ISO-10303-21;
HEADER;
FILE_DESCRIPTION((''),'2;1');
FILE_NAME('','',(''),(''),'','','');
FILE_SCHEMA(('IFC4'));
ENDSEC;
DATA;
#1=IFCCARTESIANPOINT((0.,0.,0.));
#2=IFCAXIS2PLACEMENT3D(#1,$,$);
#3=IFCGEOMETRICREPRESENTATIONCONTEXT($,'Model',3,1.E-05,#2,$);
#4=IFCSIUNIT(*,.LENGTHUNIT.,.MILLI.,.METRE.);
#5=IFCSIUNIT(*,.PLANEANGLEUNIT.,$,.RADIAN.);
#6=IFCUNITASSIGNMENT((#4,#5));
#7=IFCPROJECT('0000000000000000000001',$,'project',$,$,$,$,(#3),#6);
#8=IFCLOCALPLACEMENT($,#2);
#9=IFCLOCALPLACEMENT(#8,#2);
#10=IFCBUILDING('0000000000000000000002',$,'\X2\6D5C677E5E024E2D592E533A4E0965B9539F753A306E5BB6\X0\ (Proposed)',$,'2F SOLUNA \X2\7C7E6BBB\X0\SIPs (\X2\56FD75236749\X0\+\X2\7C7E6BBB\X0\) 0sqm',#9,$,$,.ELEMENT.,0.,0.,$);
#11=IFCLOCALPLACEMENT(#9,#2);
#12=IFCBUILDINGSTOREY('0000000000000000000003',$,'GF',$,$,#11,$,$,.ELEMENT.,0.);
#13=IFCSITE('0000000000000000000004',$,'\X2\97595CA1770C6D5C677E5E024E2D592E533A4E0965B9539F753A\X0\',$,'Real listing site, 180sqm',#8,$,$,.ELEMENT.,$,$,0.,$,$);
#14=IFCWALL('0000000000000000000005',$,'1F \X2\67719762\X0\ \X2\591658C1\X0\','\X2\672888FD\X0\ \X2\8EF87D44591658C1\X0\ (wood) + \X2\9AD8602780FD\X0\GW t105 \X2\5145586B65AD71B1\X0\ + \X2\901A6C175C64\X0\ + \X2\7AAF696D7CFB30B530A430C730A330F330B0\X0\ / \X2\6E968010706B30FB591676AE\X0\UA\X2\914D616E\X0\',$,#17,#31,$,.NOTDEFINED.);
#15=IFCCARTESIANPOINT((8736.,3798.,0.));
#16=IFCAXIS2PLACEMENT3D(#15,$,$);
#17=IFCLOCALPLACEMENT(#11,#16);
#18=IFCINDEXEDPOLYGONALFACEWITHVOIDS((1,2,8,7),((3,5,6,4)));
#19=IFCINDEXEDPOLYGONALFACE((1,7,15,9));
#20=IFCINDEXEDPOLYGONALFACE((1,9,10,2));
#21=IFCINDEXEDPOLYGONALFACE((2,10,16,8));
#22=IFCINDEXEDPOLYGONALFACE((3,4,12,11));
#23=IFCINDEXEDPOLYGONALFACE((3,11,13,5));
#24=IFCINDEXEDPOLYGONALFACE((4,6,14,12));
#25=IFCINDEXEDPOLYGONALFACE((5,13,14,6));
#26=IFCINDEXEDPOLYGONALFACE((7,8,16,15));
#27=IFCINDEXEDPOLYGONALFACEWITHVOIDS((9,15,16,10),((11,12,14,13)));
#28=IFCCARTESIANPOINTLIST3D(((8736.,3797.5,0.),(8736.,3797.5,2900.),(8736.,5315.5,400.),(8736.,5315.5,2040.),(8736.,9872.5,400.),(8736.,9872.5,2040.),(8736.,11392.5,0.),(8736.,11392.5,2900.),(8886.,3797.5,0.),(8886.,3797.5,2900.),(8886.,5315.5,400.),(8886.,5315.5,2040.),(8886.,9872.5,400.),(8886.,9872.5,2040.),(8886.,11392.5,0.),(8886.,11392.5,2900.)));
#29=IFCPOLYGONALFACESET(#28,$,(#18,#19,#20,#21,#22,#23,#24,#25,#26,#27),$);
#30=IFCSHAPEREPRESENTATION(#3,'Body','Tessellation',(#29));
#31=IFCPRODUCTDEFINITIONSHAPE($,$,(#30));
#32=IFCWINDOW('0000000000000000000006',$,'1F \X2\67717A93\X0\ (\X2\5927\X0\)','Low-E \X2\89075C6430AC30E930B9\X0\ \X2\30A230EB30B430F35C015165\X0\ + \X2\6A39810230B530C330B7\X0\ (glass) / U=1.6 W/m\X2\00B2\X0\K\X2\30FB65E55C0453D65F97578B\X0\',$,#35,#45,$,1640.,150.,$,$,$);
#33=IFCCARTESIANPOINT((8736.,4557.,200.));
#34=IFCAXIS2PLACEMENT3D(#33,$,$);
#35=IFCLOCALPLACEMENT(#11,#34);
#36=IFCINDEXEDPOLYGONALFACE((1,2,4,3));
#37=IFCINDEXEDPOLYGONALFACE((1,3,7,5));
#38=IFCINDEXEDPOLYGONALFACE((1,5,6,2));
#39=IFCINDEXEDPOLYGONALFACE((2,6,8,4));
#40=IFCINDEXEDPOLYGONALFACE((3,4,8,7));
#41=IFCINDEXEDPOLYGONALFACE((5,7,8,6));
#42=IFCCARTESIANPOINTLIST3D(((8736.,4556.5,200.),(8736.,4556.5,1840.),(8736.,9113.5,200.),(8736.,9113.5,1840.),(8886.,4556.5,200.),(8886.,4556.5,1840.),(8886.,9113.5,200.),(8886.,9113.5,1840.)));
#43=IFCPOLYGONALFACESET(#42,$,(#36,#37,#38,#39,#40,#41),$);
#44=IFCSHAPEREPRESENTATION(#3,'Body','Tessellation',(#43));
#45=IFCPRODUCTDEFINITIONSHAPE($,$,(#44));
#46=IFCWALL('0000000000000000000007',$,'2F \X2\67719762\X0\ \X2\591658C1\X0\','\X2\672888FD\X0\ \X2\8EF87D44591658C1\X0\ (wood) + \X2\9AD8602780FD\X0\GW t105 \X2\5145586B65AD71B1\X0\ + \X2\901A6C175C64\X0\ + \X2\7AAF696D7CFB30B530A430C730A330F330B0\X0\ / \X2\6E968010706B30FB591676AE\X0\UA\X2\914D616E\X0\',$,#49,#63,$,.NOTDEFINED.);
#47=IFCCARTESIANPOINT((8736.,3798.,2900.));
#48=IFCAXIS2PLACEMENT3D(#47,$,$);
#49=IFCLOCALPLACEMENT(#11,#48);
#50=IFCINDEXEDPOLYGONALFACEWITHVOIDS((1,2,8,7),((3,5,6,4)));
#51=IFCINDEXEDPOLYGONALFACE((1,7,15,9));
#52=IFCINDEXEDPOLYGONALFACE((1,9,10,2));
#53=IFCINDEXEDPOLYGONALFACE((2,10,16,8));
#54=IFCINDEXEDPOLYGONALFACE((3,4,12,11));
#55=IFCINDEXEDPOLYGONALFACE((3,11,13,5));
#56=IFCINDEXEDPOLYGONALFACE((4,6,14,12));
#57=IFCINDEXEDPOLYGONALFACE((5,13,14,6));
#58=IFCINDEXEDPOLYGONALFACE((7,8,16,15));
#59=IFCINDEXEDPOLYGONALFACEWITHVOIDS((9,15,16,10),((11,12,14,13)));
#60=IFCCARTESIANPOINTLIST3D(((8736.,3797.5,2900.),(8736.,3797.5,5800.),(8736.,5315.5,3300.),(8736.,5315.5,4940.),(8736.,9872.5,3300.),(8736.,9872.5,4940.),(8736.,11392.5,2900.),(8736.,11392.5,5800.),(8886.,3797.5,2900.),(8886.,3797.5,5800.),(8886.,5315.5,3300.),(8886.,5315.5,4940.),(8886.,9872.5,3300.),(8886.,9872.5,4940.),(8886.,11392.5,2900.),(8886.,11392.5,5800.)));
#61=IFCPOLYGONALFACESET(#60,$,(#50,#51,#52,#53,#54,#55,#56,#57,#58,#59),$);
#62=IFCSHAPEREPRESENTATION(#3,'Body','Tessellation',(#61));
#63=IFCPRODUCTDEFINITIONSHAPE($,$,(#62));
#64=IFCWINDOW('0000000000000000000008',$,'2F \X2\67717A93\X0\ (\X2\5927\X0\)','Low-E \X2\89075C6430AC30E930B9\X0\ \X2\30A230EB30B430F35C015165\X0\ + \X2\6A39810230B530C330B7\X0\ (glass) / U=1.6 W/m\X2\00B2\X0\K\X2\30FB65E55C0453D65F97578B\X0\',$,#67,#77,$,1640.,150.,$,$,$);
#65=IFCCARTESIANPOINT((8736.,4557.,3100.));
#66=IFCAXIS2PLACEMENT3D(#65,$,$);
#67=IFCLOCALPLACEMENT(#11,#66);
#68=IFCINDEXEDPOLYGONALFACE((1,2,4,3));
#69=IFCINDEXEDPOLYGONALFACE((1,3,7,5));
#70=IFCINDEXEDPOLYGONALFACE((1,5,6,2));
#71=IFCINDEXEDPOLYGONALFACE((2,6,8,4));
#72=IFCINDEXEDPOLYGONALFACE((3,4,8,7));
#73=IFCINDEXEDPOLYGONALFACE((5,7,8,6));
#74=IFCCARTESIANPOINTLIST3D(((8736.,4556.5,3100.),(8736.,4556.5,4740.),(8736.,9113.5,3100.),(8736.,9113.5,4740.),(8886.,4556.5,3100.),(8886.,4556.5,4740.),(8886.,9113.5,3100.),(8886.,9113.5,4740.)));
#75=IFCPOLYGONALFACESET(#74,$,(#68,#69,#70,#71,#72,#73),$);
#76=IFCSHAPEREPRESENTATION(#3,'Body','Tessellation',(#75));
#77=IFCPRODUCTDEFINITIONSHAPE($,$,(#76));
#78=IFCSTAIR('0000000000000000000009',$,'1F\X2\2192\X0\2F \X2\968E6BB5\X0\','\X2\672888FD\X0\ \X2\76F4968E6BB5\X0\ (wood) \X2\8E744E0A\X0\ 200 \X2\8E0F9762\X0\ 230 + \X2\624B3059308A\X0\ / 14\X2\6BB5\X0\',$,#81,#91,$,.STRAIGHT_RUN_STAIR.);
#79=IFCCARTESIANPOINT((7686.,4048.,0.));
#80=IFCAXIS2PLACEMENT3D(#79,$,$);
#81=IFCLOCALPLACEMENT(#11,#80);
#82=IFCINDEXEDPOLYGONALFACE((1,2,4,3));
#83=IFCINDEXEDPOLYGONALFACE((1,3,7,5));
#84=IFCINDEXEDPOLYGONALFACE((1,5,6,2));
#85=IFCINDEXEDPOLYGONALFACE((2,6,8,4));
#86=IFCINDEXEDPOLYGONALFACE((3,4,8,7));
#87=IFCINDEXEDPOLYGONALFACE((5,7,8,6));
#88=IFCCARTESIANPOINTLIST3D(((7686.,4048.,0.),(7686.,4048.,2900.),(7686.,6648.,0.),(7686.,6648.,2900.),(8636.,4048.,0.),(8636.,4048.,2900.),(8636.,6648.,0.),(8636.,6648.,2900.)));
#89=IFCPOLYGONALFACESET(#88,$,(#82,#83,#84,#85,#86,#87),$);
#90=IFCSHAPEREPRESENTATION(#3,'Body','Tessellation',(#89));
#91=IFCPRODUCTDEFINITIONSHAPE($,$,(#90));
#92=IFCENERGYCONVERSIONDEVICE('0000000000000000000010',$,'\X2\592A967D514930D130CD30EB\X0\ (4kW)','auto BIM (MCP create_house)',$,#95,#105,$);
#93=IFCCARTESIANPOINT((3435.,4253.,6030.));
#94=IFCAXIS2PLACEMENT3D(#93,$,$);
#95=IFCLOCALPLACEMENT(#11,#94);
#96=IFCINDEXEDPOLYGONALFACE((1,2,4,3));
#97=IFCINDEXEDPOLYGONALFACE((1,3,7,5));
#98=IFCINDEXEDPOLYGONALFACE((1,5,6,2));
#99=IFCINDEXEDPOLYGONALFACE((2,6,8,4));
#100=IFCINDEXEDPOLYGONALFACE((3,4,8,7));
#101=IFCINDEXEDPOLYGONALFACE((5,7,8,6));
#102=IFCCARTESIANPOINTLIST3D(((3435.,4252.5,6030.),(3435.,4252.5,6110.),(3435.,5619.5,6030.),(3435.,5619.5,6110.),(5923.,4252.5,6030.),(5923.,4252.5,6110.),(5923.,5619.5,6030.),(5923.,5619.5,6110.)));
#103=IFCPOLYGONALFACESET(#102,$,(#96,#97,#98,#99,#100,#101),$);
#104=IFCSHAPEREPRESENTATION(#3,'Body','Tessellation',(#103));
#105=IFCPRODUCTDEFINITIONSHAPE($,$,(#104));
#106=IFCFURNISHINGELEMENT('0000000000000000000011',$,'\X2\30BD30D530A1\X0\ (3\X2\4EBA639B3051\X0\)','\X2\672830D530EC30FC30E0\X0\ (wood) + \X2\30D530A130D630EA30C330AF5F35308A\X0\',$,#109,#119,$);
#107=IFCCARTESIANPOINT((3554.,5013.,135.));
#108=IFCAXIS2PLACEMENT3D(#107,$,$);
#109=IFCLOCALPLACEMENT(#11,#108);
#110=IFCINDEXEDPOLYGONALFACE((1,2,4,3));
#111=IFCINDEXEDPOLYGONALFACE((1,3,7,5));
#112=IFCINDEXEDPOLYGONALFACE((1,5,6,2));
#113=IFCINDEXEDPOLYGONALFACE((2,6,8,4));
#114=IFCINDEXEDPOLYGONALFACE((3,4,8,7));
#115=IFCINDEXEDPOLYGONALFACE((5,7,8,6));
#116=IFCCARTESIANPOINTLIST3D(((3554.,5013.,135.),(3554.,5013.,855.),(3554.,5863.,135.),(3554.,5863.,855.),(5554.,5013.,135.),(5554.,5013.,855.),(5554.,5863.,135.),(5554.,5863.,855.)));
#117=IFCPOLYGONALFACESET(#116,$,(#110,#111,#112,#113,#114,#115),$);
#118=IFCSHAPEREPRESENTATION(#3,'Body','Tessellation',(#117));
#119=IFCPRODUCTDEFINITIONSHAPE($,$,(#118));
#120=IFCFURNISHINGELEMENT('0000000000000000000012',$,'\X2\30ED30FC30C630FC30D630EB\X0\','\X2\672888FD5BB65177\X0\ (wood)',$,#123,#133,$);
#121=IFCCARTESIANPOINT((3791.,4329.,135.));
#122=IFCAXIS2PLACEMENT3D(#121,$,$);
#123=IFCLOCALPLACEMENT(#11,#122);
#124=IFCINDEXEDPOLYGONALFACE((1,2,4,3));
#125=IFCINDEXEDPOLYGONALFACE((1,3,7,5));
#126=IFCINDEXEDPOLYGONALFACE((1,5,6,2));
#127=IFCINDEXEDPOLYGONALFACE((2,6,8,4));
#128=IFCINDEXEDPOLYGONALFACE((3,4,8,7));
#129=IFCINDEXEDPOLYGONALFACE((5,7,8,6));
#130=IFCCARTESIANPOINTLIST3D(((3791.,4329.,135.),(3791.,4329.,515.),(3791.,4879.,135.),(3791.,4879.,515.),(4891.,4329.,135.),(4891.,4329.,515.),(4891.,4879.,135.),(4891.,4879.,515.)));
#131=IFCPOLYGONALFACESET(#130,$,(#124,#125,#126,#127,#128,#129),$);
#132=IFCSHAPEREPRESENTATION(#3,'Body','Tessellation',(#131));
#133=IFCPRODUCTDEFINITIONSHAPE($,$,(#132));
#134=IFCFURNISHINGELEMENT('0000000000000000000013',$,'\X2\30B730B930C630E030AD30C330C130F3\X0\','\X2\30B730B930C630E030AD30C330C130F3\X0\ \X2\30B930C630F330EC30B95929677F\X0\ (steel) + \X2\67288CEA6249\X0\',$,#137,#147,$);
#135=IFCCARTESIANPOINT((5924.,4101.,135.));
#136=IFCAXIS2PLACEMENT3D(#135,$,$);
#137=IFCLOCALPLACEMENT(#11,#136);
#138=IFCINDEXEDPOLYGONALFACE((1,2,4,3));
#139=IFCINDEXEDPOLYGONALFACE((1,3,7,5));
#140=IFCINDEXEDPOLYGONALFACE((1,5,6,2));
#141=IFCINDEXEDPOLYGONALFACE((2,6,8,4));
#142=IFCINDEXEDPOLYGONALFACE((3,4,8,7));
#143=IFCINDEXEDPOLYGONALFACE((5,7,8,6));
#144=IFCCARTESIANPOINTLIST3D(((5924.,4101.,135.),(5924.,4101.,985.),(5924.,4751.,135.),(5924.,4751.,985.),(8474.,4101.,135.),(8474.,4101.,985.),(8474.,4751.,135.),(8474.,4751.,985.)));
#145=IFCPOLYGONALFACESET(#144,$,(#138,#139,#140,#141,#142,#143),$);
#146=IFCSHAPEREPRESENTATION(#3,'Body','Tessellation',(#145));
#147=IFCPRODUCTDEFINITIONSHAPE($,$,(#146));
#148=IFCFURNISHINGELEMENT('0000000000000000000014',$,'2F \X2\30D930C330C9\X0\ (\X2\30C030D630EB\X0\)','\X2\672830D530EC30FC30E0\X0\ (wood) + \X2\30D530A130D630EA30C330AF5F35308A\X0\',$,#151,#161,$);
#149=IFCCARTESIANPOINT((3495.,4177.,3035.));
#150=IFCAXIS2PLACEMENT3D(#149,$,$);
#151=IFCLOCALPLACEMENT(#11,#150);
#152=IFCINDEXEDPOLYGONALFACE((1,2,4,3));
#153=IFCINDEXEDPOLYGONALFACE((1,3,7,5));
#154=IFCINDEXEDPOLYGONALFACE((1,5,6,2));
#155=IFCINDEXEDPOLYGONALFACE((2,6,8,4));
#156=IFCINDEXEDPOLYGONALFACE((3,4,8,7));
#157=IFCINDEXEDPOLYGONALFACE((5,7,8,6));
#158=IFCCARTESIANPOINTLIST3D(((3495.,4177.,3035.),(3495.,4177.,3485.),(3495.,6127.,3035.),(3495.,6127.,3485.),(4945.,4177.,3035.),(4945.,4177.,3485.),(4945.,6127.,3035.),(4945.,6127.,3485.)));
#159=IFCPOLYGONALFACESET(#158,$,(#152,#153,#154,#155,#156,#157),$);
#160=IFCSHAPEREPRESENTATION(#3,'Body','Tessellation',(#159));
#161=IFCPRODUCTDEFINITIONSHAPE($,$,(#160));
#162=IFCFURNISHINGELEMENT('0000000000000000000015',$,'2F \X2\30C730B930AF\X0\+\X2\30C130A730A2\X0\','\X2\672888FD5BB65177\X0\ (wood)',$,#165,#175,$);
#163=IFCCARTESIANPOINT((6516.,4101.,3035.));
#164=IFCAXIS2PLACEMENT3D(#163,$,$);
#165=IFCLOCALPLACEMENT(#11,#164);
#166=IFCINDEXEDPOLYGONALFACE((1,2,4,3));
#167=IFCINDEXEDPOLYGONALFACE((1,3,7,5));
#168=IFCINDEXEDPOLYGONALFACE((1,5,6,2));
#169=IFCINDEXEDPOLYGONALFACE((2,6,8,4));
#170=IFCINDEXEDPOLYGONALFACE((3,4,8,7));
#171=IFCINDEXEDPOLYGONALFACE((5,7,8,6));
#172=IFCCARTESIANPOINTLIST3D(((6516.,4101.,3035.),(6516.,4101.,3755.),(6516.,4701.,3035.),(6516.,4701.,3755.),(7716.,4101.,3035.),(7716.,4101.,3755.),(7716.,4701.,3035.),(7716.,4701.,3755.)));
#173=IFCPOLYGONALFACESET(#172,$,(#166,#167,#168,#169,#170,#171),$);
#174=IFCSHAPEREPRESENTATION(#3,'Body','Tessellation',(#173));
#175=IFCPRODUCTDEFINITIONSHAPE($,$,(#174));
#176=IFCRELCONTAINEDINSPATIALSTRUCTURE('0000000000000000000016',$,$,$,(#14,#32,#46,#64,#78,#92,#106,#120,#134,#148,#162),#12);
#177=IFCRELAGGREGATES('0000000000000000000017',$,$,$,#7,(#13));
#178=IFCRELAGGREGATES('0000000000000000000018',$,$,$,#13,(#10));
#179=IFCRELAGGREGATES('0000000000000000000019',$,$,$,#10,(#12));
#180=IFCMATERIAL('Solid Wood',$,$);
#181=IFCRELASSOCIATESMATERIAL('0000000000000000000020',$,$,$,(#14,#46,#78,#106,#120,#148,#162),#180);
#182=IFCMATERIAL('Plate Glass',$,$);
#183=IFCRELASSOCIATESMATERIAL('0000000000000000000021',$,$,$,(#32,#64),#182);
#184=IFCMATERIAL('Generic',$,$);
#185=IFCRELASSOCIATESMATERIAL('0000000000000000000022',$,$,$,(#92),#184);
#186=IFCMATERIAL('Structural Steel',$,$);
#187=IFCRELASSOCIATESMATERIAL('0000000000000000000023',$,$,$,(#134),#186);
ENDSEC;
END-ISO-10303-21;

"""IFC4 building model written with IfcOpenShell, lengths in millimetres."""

from ifc_helpers import new_model, si_unit, frame, frame_2d, origin, place, context, project, spatial, rectangle, extrude, material, element, fill, save


model = new_model("IFC4")

# Units and contexts
model_context = context("Model", 3, precision=1e-05, world=origin())
ifc_project = project(units=[si_unit("LENGTHUNIT", "METRE", prefix="MILLI"), si_unit("PLANEANGLEUNIT", "RADIAN")], contexts=[model_context])

# Site, building, storey
site_placement = place(None, origin())
site = spatial("IfcSite", under=ifc_project, at=site_placement, Name="静岡県浜松市中央区三方原町", ObjectType="Real listing site, 180sqm", CompositionType="ELEMENT", RefElevation=0.0)
building_placement = place(site_placement, origin())
building = spatial("IfcBuilding", under=site, at=building_placement, Name="浜松市中央区三方原町の家 (Proposed)", ObjectType="2F SOLUNA 籾殻SIPs (国産杉+籾殻) 0sqm", CompositionType="ELEMENT", ElevationOfRefHeight=0.0, ElevationOfTerrain=0.0)
storey_placement = place(building_placement, origin())
storey = spatial("IfcBuildingStorey", under=building, at=storey_placement, Name="GF", CompositionType="ELEMENT", Elevation=0.0)

# Wall, opening, window
ifc_material_1 = material(Name="Solid Wood")
wall_1_placement = place(storey_placement, frame((8736.0, 3798.0, 0.0)))
wall_1 = element("IfcWall", 1, at=wall_1_placement, inside=storey, material=ifc_material_1, Name="1F 東面 外壁", Description="木製 軸組外壁 (wood) + 高性能GW t105 充填断熱 + 通気層 + 窯業系サイディング / 準耐火・外皮UA配慮", PredefinedType="NOTDEFINED", context=model_context, shape_type="SweptSolid", body=[
    extrude(rectangle(XDim=150.0, YDim=7595.0, at=frame_2d((75.0, 3797.0))), frame((8736.0, 3798.0, 0.0)), (0.0, 0.0, 1.0), 2900.0),
])
opening_1_placement = place(storey_placement, frame((8736.0, 4557.0, 200.0)))
opening_1 = element("IfcOpeningElement", 2, at=opening_1_placement, cuts=wall_1, PredefinedType="NOTDEFINED", context=model_context, shape_type="SweptSolid", body=[
    extrude(rectangle(XDim=150.0, YDim=4557.0, at=frame_2d((75.0, 2278.0))), frame((8736.0, 4557.0, 200.0)), (0.0, 0.0, 1.0), 1640.0),
])
ifc_material_2 = material(Name="Plate Glass")
window_1_placement = place(storey_placement, frame((8736.0, 4557.0, 200.0)))
window_1 = element("IfcWindow", 3, at=window_1_placement, inside=storey, material=ifc_material_2, Name="1F 東窓 (大)", Description="Low-E 複層ガラス アルゴン封入 + 樹脂サッシ (glass) / U=1.6 W/m²K・日射取得型", OverallHeight=1640.0, OverallWidth=150.0, context=model_context, shape_type="SweptSolid", body=[
    extrude(rectangle(XDim=150.0, YDim=4557.0, at=frame_2d((75.0, 2278.0))), frame((8736.0, 4557.0, 200.0)), (0.0, 0.0, 1.0), 1640.0),
])
fill(opening_1, window_1)

# Wall, opening, window
wall_2_placement = place(storey_placement, frame((8736.0, 3798.0, 2900.0)))
wall_2 = element("IfcWall", 4, at=wall_2_placement, inside=storey, material=ifc_material_1, Name="2F 東面 外壁", Description="木製 軸組外壁 (wood) + 高性能GW t105 充填断熱 + 通気層 + 窯業系サイディング / 準耐火・外皮UA配慮", PredefinedType="NOTDEFINED", context=model_context, shape_type="SweptSolid", body=[
    extrude(rectangle(XDim=150.0, YDim=7595.0, at=frame_2d((75.0, 3797.0))), frame((8736.0, 3798.0, 2900.0)), (0.0, 0.0, 1.0), 2900.0),
])
opening_2_placement = place(storey_placement, frame((8736.0, 4557.0, 3100.0)))
opening_2 = element("IfcOpeningElement", 5, at=opening_2_placement, cuts=wall_2, PredefinedType="NOTDEFINED", context=model_context, shape_type="SweptSolid", body=[
    extrude(rectangle(XDim=150.0, YDim=4557.0, at=frame_2d((75.0, 2278.0))), frame((8736.0, 4557.0, 3100.0)), (0.0, 0.0, 1.0), 1640.0),
])
window_2_placement = place(storey_placement, frame((8736.0, 4557.0, 3100.0)))
window_2 = element("IfcWindow", 6, at=window_2_placement, inside=storey, material=ifc_material_2, Name="2F 東窓 (大)", Description="Low-E 複層ガラス アルゴン封入 + 樹脂サッシ (glass) / U=1.6 W/m²K・日射取得型", OverallHeight=1640.0, OverallWidth=150.0, context=model_context, shape_type="SweptSolid", body=[
    extrude(rectangle(XDim=150.0, YDim=4557.0, at=frame_2d((75.0, 2278.0))), frame((8736.0, 4557.0, 3100.0)), (0.0, 0.0, 1.0), 1640.0),
])
fill(opening_2, window_2)

# Stair
stair_placement = place(storey_placement, frame((7686.0, 4048.0, 0.0)))
element("IfcStair", 7, at=stair_placement, inside=storey, material=ifc_material_1, Name="1F→2F 階段", Description="木製 直階段 (wood) 蹴上 200 踏面 230 + 手すり / 14段", PredefinedType="STRAIGHT_RUN_STAIR", context=model_context, shape_type="SweptSolid", body=[
    extrude(rectangle(XDim=950.0, YDim=2600.0, at=frame_2d((475.0, 1300.0))), frame((7686.0, 4048.0, 0.0)), (0.0, 0.0, 1.0), 2900.0),
])

# Energy conversion device
ifc_material_3 = material(Name="Generic")
energy_conversion_device_placement = place(storey_placement, frame((3435.0, 4253.0, 6030.0)))
element("IfcEnergyConversionDevice", 8, at=energy_conversion_device_placement, inside=storey, material=ifc_material_3, Name="太陽光パネル (4kW)", Description="auto BIM (MCP create_house)", context=model_context, shape_type="SweptSolid", body=[
    extrude(rectangle(XDim=2488.0, YDim=1367.0, at=frame_2d((1244.0, 683.0))), frame((3435.0, 4253.0, 6030.0)), (0.0, 0.0, 1.0), 80.0),
])

# Furnishing elements
furnishing_1_placement = place(storey_placement, frame((3554.0, 5013.0, 135.0)))
element("IfcFurnishingElement", 9, at=furnishing_1_placement, inside=storey, material=ifc_material_1, Name="ソファ (3人掛け)", Description="木フレーム (wood) + ファブリック張り", context=model_context, shape_type="SweptSolid", body=[
    extrude(rectangle(XDim=2000.0, YDim=850.0, at=frame_2d((1000.0, 425.0))), frame((3554.0, 5013.0, 135.0)), (0.0, 0.0, 1.0), 720.0),
])
furnishing_2_placement = place(storey_placement, frame((3791.0, 4329.0, 135.0)))
element("IfcFurnishingElement", 10, at=furnishing_2_placement, inside=storey, material=ifc_material_1, Name="ローテーブル", Description="木製家具 (wood)", context=model_context, shape_type="SweptSolid", body=[
    extrude(rectangle(XDim=1100.0, YDim=550.0, at=frame_2d((550.0, 275.0))), frame((3791.0, 4329.0, 135.0)), (0.0, 0.0, 1.0), 380.0),
])
ifc_material_4 = material(Name="Structural Steel")
furnishing_3_placement = place(storey_placement, frame((5924.0, 4101.0, 135.0)))
element("IfcFurnishingElement", 11, at=furnishing_3_placement, inside=storey, material=ifc_material_4, Name="システムキッチン", Description="システムキッチン ステンレス天板 (steel) + 木質扉", context=model_context, shape_type="SweptSolid", body=[
    extrude(rectangle(XDim=2550.0, YDim=650.0, at=frame_2d((1275.0, 325.0))), frame((5924.0, 4101.0, 135.0)), (0.0, 0.0, 1.0), 850.0),
])
furnishing_4_placement = place(storey_placement, frame((3495.0, 4177.0, 3035.0)))
element("IfcFurnishingElement", 12, at=furnishing_4_placement, inside=storey, material=ifc_material_1, Name="2F ベッド (ダブル)", Description="木フレーム (wood) + ファブリック張り", context=model_context, shape_type="SweptSolid", body=[
    extrude(rectangle(XDim=1450.0, YDim=1950.0, at=frame_2d((725.0, 975.0))), frame((3495.0, 4177.0, 3035.0)), (0.0, 0.0, 1.0), 450.0),
])
furnishing_5_placement = place(storey_placement, frame((6516.0, 4101.0, 3035.0)))
element("IfcFurnishingElement", 13, at=furnishing_5_placement, inside=storey, material=ifc_material_1, Name="2F デスク+チェア", Description="木製家具 (wood)", context=model_context, shape_type="SweptSolid", body=[
    extrude(rectangle(XDim=1200.0, YDim=600.0, at=frame_2d((600.0, 300.0))), frame((6516.0, 4101.0, 3035.0)), (0.0, 0.0, 1.0), 720.0),
])

save(model, "model.ifc")
